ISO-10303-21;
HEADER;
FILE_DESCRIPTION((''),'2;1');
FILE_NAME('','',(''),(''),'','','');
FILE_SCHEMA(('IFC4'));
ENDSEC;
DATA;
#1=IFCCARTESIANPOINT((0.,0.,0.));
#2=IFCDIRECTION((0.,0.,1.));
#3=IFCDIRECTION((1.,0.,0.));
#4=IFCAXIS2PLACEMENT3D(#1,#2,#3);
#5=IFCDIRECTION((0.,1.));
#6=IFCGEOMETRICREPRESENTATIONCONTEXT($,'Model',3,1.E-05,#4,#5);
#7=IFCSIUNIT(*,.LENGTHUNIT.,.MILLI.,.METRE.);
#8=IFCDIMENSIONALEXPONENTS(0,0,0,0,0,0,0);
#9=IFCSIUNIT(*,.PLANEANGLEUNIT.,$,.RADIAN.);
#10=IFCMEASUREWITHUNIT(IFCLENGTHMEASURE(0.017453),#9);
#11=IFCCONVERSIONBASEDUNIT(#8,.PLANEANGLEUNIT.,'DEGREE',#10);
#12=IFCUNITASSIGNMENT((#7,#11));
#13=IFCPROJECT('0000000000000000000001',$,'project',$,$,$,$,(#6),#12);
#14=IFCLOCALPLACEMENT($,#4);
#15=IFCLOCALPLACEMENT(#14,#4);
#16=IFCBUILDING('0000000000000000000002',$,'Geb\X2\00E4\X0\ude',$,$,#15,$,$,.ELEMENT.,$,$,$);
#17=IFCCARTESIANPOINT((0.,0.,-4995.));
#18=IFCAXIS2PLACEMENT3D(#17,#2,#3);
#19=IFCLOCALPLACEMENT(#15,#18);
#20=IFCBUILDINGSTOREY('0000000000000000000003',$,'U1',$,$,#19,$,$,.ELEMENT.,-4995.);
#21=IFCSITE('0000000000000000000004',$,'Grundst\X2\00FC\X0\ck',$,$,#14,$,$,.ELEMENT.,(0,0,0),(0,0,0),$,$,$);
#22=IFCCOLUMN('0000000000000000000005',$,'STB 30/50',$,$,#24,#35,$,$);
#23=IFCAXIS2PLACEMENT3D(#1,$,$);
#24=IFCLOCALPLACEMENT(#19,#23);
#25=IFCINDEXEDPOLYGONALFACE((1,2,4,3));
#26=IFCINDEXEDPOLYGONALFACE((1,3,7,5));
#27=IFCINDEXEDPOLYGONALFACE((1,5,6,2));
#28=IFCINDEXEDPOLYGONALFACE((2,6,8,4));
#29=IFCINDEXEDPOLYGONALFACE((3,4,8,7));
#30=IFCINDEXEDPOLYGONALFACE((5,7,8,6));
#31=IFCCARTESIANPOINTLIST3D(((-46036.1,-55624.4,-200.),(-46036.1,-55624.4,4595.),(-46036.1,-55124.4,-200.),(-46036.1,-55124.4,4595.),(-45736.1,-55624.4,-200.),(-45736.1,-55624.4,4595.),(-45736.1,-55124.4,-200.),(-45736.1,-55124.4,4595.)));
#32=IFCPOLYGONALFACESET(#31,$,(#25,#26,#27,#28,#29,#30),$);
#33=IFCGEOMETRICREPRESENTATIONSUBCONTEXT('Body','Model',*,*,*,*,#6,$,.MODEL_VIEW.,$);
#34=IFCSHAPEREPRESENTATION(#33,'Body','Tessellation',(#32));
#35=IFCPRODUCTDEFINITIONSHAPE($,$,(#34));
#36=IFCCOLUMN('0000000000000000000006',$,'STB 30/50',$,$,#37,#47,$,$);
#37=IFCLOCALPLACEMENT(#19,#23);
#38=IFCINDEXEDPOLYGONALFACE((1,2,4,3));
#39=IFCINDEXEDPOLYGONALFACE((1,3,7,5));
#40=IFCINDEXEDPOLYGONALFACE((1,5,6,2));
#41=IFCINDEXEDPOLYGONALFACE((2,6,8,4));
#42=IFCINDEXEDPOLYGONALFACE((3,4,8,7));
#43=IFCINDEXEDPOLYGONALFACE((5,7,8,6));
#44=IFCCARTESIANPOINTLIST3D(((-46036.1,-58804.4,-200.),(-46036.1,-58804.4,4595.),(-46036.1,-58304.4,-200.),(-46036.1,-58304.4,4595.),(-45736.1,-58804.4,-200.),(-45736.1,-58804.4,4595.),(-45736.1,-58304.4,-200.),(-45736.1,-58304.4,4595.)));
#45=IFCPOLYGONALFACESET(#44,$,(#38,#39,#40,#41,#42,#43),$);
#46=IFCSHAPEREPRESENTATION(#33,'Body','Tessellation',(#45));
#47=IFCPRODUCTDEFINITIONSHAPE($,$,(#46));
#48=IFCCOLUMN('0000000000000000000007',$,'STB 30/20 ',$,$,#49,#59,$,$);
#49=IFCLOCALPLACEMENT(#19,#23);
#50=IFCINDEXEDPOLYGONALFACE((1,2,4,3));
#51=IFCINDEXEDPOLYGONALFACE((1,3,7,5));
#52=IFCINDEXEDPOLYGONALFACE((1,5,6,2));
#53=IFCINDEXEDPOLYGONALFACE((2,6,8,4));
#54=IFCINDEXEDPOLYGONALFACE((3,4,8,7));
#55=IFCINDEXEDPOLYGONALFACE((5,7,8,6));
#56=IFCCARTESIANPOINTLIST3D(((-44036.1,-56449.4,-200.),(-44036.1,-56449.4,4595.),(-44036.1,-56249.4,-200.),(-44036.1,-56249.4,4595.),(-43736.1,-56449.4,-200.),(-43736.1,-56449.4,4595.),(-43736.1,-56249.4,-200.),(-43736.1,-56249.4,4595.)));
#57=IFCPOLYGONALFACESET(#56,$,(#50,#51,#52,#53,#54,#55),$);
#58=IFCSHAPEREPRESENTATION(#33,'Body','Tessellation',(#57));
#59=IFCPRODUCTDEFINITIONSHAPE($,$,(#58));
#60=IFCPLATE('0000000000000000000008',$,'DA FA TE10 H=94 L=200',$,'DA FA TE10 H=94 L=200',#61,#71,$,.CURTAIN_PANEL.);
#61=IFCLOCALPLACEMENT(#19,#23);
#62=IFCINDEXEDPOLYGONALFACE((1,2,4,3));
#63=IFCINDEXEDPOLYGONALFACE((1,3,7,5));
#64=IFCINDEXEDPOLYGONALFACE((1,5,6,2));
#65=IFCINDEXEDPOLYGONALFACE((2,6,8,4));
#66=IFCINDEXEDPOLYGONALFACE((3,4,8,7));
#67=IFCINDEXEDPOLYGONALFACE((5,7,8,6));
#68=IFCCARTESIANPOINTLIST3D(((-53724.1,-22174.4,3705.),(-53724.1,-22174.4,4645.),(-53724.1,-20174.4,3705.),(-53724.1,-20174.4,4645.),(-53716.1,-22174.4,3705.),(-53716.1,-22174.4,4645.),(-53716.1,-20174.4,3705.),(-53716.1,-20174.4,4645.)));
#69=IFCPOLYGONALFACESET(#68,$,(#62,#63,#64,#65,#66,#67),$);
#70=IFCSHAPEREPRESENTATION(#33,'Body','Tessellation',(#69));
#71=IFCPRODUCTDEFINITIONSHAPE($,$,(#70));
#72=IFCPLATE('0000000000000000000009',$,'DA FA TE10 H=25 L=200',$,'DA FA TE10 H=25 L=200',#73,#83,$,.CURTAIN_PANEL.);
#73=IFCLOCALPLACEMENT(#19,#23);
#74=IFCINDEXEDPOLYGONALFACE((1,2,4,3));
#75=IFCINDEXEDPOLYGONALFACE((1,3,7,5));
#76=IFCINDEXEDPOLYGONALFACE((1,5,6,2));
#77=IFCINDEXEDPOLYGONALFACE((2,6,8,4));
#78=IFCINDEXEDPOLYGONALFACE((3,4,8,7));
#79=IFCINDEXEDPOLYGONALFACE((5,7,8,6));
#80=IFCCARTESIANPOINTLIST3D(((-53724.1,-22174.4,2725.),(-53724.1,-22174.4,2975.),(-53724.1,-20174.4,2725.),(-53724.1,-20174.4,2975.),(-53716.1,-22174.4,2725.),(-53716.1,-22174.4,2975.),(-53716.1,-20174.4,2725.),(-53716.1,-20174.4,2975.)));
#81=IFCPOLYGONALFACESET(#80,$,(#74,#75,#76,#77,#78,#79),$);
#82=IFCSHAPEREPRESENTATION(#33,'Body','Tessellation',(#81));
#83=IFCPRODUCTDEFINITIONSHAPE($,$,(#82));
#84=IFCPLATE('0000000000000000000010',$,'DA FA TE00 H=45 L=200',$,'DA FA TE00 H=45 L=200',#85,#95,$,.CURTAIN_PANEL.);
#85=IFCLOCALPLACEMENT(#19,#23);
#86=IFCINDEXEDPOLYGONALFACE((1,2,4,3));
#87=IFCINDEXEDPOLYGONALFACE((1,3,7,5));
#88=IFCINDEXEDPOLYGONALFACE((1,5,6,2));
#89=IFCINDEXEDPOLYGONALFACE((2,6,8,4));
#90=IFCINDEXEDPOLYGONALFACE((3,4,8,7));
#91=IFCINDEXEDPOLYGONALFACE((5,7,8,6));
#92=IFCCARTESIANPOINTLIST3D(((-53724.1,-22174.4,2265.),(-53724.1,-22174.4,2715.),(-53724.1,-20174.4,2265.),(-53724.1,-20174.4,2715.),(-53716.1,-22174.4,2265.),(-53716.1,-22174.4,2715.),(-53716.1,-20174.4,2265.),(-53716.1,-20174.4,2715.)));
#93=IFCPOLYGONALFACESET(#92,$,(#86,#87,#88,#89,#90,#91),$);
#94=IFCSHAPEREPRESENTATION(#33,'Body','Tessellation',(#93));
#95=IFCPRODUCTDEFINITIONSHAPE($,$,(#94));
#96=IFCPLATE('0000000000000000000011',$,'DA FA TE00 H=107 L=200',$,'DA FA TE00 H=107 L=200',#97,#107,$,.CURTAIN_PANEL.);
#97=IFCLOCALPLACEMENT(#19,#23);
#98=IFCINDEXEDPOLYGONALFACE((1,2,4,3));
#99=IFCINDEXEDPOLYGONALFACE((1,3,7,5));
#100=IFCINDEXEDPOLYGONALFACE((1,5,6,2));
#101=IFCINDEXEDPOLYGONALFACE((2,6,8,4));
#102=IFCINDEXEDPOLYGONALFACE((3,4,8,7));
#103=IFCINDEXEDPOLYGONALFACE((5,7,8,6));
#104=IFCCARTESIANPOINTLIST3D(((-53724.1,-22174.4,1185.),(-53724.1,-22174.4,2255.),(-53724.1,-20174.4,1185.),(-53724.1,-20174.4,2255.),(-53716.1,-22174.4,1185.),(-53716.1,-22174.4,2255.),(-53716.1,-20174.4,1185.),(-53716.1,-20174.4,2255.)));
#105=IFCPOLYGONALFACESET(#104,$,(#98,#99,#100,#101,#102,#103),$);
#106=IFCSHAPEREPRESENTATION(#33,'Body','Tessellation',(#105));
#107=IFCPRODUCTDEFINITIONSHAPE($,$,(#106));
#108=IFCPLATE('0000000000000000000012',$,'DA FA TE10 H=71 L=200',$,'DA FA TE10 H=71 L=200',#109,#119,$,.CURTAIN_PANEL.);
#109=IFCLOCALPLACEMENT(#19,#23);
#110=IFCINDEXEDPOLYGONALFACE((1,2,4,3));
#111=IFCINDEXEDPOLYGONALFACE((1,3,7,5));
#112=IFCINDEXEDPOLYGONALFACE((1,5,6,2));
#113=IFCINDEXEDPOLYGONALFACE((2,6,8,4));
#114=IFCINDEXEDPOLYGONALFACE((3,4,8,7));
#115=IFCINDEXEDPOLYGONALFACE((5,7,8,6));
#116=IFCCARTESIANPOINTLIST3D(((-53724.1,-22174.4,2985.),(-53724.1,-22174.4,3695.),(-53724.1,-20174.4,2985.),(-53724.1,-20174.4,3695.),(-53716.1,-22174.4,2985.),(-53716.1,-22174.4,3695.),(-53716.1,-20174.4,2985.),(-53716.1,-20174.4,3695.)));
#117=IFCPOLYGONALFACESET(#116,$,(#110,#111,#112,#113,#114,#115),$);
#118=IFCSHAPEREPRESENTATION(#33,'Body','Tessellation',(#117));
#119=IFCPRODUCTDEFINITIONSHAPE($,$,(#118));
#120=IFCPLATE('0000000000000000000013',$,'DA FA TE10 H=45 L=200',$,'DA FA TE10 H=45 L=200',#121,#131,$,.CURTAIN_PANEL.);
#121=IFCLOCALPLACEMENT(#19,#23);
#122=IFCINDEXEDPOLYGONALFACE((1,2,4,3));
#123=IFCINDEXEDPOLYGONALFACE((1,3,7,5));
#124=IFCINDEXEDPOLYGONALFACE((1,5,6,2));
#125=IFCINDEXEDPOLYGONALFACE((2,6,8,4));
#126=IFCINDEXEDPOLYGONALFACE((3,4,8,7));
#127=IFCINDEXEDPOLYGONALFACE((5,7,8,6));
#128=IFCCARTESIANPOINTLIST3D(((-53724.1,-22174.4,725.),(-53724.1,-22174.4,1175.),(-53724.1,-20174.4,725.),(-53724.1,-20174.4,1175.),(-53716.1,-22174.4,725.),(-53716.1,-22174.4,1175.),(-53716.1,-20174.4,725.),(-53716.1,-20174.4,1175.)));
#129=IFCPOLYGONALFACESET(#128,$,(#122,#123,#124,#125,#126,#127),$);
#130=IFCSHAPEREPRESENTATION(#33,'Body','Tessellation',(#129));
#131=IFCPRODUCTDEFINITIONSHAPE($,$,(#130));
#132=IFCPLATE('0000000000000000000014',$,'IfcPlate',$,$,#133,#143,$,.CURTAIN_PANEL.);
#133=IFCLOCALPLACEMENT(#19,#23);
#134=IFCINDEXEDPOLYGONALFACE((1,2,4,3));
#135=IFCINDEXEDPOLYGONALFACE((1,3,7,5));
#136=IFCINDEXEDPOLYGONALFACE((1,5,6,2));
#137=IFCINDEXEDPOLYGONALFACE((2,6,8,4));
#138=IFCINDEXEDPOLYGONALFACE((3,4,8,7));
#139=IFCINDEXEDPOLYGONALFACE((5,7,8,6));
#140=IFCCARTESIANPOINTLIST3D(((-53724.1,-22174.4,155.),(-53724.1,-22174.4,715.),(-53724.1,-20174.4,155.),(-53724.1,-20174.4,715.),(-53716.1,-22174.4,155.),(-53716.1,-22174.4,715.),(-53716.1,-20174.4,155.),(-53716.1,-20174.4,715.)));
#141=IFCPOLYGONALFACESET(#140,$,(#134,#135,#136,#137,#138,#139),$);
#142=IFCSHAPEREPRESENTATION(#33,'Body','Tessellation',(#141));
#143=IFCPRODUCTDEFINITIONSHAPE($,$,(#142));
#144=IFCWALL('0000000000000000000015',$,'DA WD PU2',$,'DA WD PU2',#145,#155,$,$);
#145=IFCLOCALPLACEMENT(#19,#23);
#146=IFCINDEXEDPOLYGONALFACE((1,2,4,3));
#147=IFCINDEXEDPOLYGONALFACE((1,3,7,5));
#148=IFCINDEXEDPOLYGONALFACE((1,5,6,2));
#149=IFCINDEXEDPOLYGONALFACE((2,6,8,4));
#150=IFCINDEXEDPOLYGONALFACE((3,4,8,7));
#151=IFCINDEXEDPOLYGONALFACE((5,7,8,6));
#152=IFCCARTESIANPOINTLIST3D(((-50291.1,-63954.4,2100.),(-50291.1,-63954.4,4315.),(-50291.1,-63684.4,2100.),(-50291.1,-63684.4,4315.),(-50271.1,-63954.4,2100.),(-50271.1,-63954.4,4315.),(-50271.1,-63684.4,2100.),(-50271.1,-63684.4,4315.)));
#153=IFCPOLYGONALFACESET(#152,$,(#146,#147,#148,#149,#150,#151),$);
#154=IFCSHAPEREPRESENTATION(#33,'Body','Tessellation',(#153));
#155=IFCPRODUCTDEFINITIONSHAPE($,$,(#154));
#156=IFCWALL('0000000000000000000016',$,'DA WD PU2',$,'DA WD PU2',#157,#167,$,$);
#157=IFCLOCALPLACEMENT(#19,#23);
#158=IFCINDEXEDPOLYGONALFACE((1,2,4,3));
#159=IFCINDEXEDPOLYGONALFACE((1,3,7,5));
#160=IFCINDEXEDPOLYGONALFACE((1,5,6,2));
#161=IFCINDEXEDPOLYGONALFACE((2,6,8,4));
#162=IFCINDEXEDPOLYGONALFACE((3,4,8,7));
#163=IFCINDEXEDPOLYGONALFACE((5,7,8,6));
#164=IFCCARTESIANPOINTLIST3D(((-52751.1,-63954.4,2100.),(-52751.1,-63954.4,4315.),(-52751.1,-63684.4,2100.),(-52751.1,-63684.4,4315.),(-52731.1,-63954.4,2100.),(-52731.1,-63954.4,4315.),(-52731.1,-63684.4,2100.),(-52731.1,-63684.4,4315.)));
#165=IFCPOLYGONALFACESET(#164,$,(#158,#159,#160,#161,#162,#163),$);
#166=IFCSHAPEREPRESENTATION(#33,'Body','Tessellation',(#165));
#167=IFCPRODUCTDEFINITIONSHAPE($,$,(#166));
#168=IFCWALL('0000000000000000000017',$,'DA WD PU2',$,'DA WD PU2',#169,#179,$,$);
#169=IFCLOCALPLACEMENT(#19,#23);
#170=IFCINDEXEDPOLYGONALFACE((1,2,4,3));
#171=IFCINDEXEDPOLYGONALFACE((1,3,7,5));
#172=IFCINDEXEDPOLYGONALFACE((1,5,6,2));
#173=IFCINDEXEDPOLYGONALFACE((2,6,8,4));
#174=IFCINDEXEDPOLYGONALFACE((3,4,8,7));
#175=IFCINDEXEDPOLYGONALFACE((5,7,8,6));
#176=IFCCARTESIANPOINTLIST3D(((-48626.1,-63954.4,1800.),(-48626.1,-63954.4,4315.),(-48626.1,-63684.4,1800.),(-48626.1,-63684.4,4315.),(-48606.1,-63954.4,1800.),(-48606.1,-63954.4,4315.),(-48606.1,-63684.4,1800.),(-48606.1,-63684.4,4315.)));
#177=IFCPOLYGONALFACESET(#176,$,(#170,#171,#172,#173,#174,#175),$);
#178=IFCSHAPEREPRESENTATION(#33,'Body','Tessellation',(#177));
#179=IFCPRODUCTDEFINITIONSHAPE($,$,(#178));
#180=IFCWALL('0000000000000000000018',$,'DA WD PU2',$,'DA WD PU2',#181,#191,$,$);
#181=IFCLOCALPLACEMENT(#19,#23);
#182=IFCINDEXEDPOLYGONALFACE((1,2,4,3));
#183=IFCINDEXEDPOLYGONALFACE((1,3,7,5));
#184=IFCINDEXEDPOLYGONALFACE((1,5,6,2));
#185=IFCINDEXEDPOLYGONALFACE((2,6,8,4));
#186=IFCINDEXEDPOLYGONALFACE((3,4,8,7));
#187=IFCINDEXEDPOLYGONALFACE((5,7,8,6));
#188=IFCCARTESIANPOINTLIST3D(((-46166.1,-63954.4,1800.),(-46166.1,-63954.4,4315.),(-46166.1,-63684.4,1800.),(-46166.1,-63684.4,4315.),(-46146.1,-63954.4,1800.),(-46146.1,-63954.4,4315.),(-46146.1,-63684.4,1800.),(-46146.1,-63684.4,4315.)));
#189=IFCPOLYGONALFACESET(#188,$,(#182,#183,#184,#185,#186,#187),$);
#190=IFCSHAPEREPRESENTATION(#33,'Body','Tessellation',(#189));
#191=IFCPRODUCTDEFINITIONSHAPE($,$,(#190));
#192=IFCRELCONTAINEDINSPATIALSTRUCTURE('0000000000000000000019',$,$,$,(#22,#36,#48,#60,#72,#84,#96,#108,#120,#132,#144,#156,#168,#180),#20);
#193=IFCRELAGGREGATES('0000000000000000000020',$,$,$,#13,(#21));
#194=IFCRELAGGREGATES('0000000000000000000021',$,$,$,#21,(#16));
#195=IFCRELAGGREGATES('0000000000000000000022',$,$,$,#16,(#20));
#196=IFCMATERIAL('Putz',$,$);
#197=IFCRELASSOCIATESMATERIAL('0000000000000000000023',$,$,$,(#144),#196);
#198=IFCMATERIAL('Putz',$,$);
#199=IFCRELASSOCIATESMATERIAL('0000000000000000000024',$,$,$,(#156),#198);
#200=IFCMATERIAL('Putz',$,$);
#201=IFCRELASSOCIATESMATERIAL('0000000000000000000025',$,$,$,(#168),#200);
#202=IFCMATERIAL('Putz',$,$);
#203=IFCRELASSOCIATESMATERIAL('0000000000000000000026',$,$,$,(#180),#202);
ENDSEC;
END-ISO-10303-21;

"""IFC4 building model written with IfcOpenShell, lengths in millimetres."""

from ifc_helpers import new_model, entity, si_unit, converted_unit, direction, frame, origin_with_axes, place, context, subcontext, project, spatial, line, indexed_curve, outline, extrude, material, element, save


model = new_model("IFC4")

# Units and contexts
model_context = context("Model", 3, precision=1e-05, world=origin_with_axes(), true_north=direction((0.0, 1.0)))
body_context = subcontext(model_context, "Body", "Model", "MODEL_VIEW")
ifc_project = project(units=[si_unit("LENGTHUNIT", "METRE", prefix="MILLI"), converted_unit("PLANEANGLEUNIT", "DEGREE", entity("IfcLengthMeasure", 0.017453), si_unit("PLANEANGLEUNIT", "RADIAN"), dimensions=[0, 0, 0, 0, 0, 0, 0])], contexts=[model_context])

# Site, building, storey
site_placement = place(None, origin_with_axes())
site = spatial("IfcSite", under=ifc_project, at=site_placement, Name="Grundstück", CompositionType="ELEMENT", RefLatitude=(0, 0, 0), RefLongitude=(0, 0, 0))
building_placement = place(site_placement, origin_with_axes())
building = spatial("IfcBuilding", under=site, at=building_placement, Name="Gebäude", CompositionType="ELEMENT")
storey_placement = place(building_placement, frame((0.0, 0.0, -4995.0), z_axis=(0.0, 0.0, 1.0), x_axis=(1.0, 0.0, 0.0)))
storey = spatial("IfcBuildingStorey", under=building, at=storey_placement, Name="U1", CompositionType="ELEMENT", Elevation=-4995.0)

# Columns
for number, where, z_axis, x_axis, name in (
    (1, (-45886.1, -55374.4, -200.0), (0.0, 0.0, 1.0), (1.0, 0.0, 0.0), "STB 30/50"),
    (2, (-45886.1, -58554.4, -200.0), (0.0, 0.0, 1.0), (1.0, 0.0, 0.0), "STB 30/50"),
):
    element("IfcColumn", number, at=place(storey_placement, frame(where, z_axis=z_axis, x_axis=x_axis)), inside=storey, Name=name, context=body_context, shape_type="SweptSolid", body=[
        extrude(outline(indexed_curve([(-150.0, -250.0), (150.0, -250.0), (150.0, 250.0), (-150.0, 250.0)], segments=[line(1, 2), line(2, 3), line(3, 4), line(4, 1)])), origin_with_axes(), (0.0, 0.0, 1.0), 4795.0),
    ])
column_placement = place(storey_placement, frame((-43886.1, -56349.4, -200.0), z_axis=(0.0, 0.0, 1.0), x_axis=(1.0, 0.0, 0.0)))
element("IfcColumn", 3, at=column_placement, inside=storey, Name="STB 30/20 ", context=body_context, shape_type="SweptSolid", body=[
    extrude(outline(indexed_curve([(-150.0, -100.0), (150.0, -100.0), (150.0, 100.0), (-150.0, 100.0)], segments=[line(1, 2), line(2, 3), line(3, 4), line(4, 1)])), origin_with_axes(), (0.0, 0.0, 1.0), 4795.0),
])

# Plates
plate_1_placement = place(storey_placement, frame((-53716.1, -21174.4, 3705.0), z_axis=(0.0, 0.0, 1.0), x_axis=(0.0, 1.0, 0.0)))
element("IfcPlate", 4, at=plate_1_placement, inside=storey, Name="DA FA TE10 H=94 L=200", ObjectType="DA FA TE10 H=94 L=200", PredefinedType="CURTAIN_PANEL", context=body_context, shape_type="SweptSolid", body=[
    extrude(outline(indexed_curve([(-1000.0, 0.0), (1000.0, 0.0), (1000.0, 8.0), (-1000.0, 8.0)], segments=[line(1, 2), line(2, 3), line(3, 4), line(4, 1)])), frame((0.0, 0.0, 940.0), z_axis=(0.0, 0.0, 1.0), x_axis=(1.0, 0.0, 0.0)), (0.0, 0.0, -1.0), 940.0),
])
plate_2_placement = place(storey_placement, frame((-53716.1, -21174.4, 2725.0), z_axis=(0.0, 0.0, 1.0), x_axis=(0.0, 1.0, 0.0)))
element("IfcPlate", 5, at=plate_2_placement, inside=storey, Name="DA FA TE10 H=25 L=200", ObjectType="DA FA TE10 H=25 L=200", PredefinedType="CURTAIN_PANEL", context=body_context, shape_type="SweptSolid", body=[
    extrude(outline(indexed_curve([(-1000.0, 0.0), (1000.0, 0.0), (1000.0, 8.0), (-1000.0, 8.0)], segments=[line(1, 2), line(2, 3), line(3, 4), line(4, 1)])), frame((0.0, 0.0, 250.0), z_axis=(0.0, 0.0, 1.0), x_axis=(1.0, 0.0, 0.0)), (0.0, 0.0, -1.0), 250.0),
])
plate_3_placement = place(storey_placement, frame((-53716.1, -21174.4, 2265.0), z_axis=(0.0, 0.0, 1.0), x_axis=(0.0, 1.0, 0.0)))
element("IfcPlate", 6, at=plate_3_placement, inside=storey, Name="DA FA TE00 H=45 L=200", ObjectType="DA FA TE00 H=45 L=200", PredefinedType="CURTAIN_PANEL", context=body_context, shape_type="SweptSolid", body=[
    extrude(outline(indexed_curve([(-1000.0, 0.0), (1000.0, 0.0), (1000.0, 8.0), (-1000.0, 8.0)], segments=[line(1, 2), line(2, 3), line(3, 4), line(4, 1)])), frame((0.0, 0.0, 450.0), z_axis=(0.0, 0.0, 1.0), x_axis=(1.0, 0.0, 0.0)), (0.0, 0.0, -1.0), 450.0),
])
plate_4_placement = place(storey_placement, frame((-53716.1, -21174.4, 1185.0), z_axis=(0.0, 0.0, 1.0), x_axis=(0.0, 1.0, 0.0)))
element("IfcPlate", 7, at=plate_4_placement, inside=storey, Name="DA FA TE00 H=107 L=200", ObjectType="DA FA TE00 H=107 L=200", PredefinedType="CURTAIN_PANEL", context=body_context, shape_type="SweptSolid", body=[
    extrude(outline(indexed_curve([(-1000.0, 0.0), (1000.0, 0.0), (1000.0, 8.0), (-1000.0, 8.0)], segments=[line(1, 2), line(2, 3), line(3, 4), line(4, 1)])), frame((0.0, 0.0, 1070.0), z_axis=(0.0, 0.0, 1.0), x_axis=(1.0, 0.0, 0.0)), (0.0, 0.0, -1.0), 1070.0),
])
plate_5_placement = place(storey_placement, frame((-53716.1, -21174.4, 2985.0), z_axis=(0.0, 0.0, 1.0), x_axis=(0.0, 1.0, 0.0)))
element("IfcPlate", 8, at=plate_5_placement, inside=storey, Name="DA FA TE10 H=71 L=200", ObjectType="DA FA TE10 H=71 L=200", PredefinedType="CURTAIN_PANEL", context=body_context, shape_type="SweptSolid", body=[
    extrude(outline(indexed_curve([(-1000.0, 0.0), (1000.0, 0.0), (1000.0, 8.0), (-1000.0, 8.0)], segments=[line(1, 2), line(2, 3), line(3, 4), line(4, 1)])), frame((0.0, 0.0, 710.0), z_axis=(0.0, 0.0, 1.0), x_axis=(1.0, 0.0, 0.0)), (0.0, 0.0, -1.0), 710.0),
])
plate_6_placement = place(storey_placement, frame((-53716.1, -21174.4, 725.0), z_axis=(0.0, 0.0, 1.0), x_axis=(0.0, 1.0, 0.0)))
element("IfcPlate", 9, at=plate_6_placement, inside=storey, Name="DA FA TE10 H=45 L=200", ObjectType="DA FA TE10 H=45 L=200", PredefinedType="CURTAIN_PANEL", context=body_context, shape_type="SweptSolid", body=[
    extrude(outline(indexed_curve([(-1000.0, 0.0), (1000.0, 0.0), (1000.0, 8.0), (-1000.0, 8.0)], segments=[line(1, 2), line(2, 3), line(3, 4), line(4, 1)])), frame((0.0, 0.0, 450.0), z_axis=(0.0, 0.0, 1.0), x_axis=(1.0, 0.0, 0.0)), (0.0, 0.0, -1.0), 450.0),
])
plate_7_placement = place(storey_placement, frame((-53716.1, -21174.4, 5.0), z_axis=(0.0, 0.0, 1.0), x_axis=(0.0, 1.0, 0.0)))
element("IfcPlate", 10, at=plate_7_placement, inside=storey, Name="IfcPlate", PredefinedType="CURTAIN_PANEL", context=body_context, shape_type="SweptSolid", body=[
    extrude(outline(indexed_curve([(-1000.0, 0.0), (1000.0, 0.0), (1000.0, 8.0), (-1000.0, 8.0)], segments=[line(1, 2), line(2, 3), line(3, 4), line(4, 1)])), frame((0.0, 0.0, 710.0), z_axis=(0.0, 0.0, 1.0), x_axis=(1.0, 0.0, 0.0)), (0.0, 0.0, -1.0), 560.0),
])

# Walls
ifc_material_1 = material(Name="Putz")
wall_1_placement = place(storey_placement, frame((-50281.1, -63684.4, 2100.0), z_axis=(0.0, 0.0, 1.0), x_axis=(0.0, -1.0, 0.0)))
element("IfcWall", 11, at=wall_1_placement, inside=storey, material=ifc_material_1, Name="DA WD PU2", ObjectType="DA WD PU2", context=body_context, shape_type="SweptSolid", body=[
    extrude(outline(indexed_curve([(0.0, -10.0), (0.0, 10.0), (270.0, 10.0), (270.0, -10.0)], segments=[line(1, 2), line(2, 3), line(3, 4), line(4, 1)])), origin_with_axes(), (0.0, 0.0, 1.0), 2215.0),
])
ifc_material_2 = material(Name="Putz")
wall_2_placement = place(storey_placement, frame((-52741.1, -63684.4, 2100.0), z_axis=(0.0, 0.0, 1.0), x_axis=(0.0, -1.0, 0.0)))
element("IfcWall", 12, at=wall_2_placement, inside=storey, material=ifc_material_2, Name="DA WD PU2", ObjectType="DA WD PU2", context=body_context, shape_type="SweptSolid", body=[
    extrude(outline(indexed_curve([(0.0, -10.0), (0.0, 10.0), (270.0, 10.0), (270.0, -10.0)], segments=[line(1, 2), line(2, 3), line(3, 4), line(4, 1)])), origin_with_axes(), (0.0, 0.0, 1.0), 2215.0),
])
ifc_material_3 = material(Name="Putz")
wall_3_placement = place(storey_placement, frame((-48616.1, -63954.4, 1800.0), z_axis=(0.0, 0.0, 1.0), x_axis=(0.0, 1.0, 0.0)))
element("IfcWall", 13, at=wall_3_placement, inside=storey, material=ifc_material_3, Name="DA WD PU2", ObjectType="DA WD PU2", context=body_context, shape_type="SweptSolid", body=[
    extrude(outline(indexed_curve([(0.0, -10.0), (0.0, 10.0), (270.0, 10.0), (270.0, -10.0)], segments=[line(1, 2), line(2, 3), line(3, 4), line(4, 1)])), origin_with_axes(), (0.0, 0.0, 1.0), 2515.0),
])
ifc_material_4 = material(Name="Putz")
wall_4_placement = place(storey_placement, frame((-46156.1, -63954.4, 1800.0), z_axis=(0.0, 0.0, 1.0), x_axis=(0.0, 1.0, 0.0)))
element("IfcWall", 14, at=wall_4_placement, inside=storey, material=ifc_material_4, Name="DA WD PU2", ObjectType="DA WD PU2", context=body_context, shape_type="SweptSolid", body=[
    extrude(outline(indexed_curve([(0.0, -10.0), (0.0, 10.0), (270.0, 10.0), (270.0, -10.0)], segments=[line(1, 2), line(2, 3), line(3, 4), line(4, 1)])), origin_with_axes(), (0.0, 0.0, 1.0), 2515.0),
])

save(model, "model.ifc")
